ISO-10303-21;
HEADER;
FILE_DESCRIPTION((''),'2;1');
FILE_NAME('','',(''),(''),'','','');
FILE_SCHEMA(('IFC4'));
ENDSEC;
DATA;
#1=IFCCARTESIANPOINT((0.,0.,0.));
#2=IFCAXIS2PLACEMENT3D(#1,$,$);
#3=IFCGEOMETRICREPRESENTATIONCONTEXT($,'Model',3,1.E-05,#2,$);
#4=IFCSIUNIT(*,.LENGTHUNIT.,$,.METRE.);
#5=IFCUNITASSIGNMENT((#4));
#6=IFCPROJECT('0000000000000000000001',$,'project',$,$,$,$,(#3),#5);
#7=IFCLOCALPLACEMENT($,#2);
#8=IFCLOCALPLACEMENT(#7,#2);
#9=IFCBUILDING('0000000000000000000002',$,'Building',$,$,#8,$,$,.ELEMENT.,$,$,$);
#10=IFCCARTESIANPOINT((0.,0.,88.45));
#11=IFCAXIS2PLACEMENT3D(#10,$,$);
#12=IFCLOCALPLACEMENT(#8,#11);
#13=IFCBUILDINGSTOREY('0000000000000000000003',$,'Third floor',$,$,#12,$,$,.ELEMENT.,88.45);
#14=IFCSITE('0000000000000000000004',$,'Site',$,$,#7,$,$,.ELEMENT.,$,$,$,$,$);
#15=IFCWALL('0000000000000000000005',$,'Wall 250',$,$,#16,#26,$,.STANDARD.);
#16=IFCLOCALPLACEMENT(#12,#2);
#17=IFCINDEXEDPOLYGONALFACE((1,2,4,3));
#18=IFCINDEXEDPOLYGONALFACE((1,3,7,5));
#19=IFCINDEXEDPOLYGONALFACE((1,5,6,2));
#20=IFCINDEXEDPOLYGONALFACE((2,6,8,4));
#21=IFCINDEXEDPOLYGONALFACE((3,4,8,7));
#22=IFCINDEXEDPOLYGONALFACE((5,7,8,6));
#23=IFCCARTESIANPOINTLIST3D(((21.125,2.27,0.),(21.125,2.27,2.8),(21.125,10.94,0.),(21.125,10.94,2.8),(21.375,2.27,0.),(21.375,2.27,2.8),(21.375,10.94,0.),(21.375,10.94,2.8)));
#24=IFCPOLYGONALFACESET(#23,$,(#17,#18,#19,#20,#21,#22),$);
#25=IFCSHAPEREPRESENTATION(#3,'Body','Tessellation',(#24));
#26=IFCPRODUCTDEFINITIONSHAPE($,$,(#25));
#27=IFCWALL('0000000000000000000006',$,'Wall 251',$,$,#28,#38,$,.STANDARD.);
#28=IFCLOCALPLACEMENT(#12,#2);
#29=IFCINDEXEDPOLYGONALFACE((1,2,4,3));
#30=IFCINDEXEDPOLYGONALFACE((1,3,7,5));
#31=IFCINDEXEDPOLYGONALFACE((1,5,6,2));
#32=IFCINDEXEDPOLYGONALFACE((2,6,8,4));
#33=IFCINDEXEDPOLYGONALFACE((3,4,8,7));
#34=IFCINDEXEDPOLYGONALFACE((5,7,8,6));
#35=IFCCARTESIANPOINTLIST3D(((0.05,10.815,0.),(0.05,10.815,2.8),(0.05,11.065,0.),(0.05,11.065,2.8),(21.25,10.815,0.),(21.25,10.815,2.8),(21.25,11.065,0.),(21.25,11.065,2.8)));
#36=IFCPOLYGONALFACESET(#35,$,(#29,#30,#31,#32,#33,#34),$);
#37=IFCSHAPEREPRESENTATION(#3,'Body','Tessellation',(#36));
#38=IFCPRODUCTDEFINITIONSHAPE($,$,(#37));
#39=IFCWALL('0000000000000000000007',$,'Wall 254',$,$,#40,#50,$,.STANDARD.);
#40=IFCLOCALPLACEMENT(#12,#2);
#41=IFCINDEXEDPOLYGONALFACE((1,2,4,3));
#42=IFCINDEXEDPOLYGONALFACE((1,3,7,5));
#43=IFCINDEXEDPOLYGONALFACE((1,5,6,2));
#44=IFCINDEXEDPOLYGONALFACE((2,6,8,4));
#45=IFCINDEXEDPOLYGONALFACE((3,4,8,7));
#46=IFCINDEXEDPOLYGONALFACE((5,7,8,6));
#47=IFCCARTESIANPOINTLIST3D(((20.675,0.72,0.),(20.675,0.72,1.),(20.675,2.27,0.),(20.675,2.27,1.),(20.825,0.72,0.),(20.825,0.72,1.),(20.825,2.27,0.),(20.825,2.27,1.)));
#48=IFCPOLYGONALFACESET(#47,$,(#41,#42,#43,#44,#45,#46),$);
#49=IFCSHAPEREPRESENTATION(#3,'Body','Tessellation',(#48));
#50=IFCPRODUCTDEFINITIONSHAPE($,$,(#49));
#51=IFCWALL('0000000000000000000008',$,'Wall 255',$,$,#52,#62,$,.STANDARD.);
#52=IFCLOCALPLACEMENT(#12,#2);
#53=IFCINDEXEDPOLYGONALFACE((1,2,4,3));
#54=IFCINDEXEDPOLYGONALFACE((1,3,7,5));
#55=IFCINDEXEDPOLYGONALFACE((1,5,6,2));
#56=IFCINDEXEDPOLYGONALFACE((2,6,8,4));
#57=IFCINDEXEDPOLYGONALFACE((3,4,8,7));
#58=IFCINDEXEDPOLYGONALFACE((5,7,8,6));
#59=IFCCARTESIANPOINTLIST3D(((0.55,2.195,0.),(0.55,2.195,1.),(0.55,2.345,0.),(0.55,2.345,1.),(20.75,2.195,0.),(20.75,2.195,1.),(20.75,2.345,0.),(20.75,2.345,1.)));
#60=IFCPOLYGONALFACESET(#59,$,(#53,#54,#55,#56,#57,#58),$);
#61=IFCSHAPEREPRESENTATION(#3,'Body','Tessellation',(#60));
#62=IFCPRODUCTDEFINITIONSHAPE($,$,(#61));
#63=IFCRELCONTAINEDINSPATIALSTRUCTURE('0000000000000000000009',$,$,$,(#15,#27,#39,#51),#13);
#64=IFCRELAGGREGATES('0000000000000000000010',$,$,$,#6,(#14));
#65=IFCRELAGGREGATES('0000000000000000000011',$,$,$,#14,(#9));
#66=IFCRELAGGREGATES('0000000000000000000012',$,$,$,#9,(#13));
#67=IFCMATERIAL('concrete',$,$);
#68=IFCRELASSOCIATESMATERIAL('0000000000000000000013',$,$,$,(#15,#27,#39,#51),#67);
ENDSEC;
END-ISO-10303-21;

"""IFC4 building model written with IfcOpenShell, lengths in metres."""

from ifc_helpers import new_model, si_unit, frame, frame_2d, origin, place, context, project, spatial, rectangle, extrude, material, element, save


model = new_model("IFC4")

# Units and contexts
model_context = context("Model", 3, precision=1e-05, world=origin())
ifc_project = project(units=[si_unit("LENGTHUNIT", "METRE")], contexts=[model_context])

# Site, building, storey
site_placement = place(None, origin())
site = spatial("IfcSite", under=ifc_project, at=site_placement, Name="Site", CompositionType="ELEMENT")
building_placement = place(site_placement, origin())
building = spatial("IfcBuilding", under=site, at=building_placement, Name="Building", CompositionType="ELEMENT")
storey_placement = place(building_placement, frame((0.0, 0.0, 88.45)))
storey = spatial("IfcBuildingStorey", under=building, at=storey_placement, Name="Third floor", CompositionType="ELEMENT", Elevation=88.45)

# Walls
ifc_material = material(Name="concrete")
wall_1_placement = place(storey_placement, frame((21.25, 2.27, 0.0), z_axis=(0.0, 0.0, 1.0), x_axis=(0.0, 1.0, 0.0)))
element("IfcWall", 1, at=wall_1_placement, inside=storey, material=ifc_material, Name="Wall 250", PredefinedType="STANDARD", context=model_context, shape_type="SweptSolid", body=[
    extrude(rectangle(XDim=8.67, YDim=0.25, at=frame_2d((4.335, 0.0))), origin(), (0.0, 0.0, 1.0), 2.8),
])
wall_2_placement = place(storey_placement, frame((21.25, 10.94, 0.0), z_axis=(0.0, 0.0, 1.0), x_axis=(-1.0, 0.0, 0.0)))
element("IfcWall", 2, at=wall_2_placement, inside=storey, material=ifc_material, Name="Wall 251", PredefinedType="STANDARD", context=model_context, shape_type="SweptSolid", body=[
    extrude(rectangle(XDim=21.2, YDim=0.25, at=frame_2d((10.6, 0.0))), origin(), (0.0, 0.0, 1.0), 2.8),
])
wall_3_placement = place(storey_placement, frame((20.75, 0.72, 0.0), z_axis=(0.0, 0.0, 1.0), x_axis=(0.0, 1.0, 0.0)))
element("IfcWall", 3, at=wall_3_placement, inside=storey, material=ifc_material, Name="Wall 254", PredefinedType="STANDARD", context=model_context, shape_type="SweptSolid", body=[
    extrude(rectangle(XDim=1.55, YDim=0.15, at=frame_2d((0.775, 0.0))), origin(), (0.0, 0.0, 1.0), 1.0),
])
wall_4_placement = place(storey_placement, frame((20.75, 2.27, 0.0), z_axis=(0.0, 0.0, 1.0), x_axis=(-1.0, 0.0, 0.0)))
element("IfcWall", 4, at=wall_4_placement, inside=storey, material=ifc_material, Name="Wall 255", PredefinedType="STANDARD", context=model_context, shape_type="SweptSolid", body=[
    extrude(rectangle(XDim=20.2, YDim=0.15, at=frame_2d((10.1, 0.0))), origin(), (0.0, 0.0, 1.0), 1.0),
])

save(model, "model.ifc")
